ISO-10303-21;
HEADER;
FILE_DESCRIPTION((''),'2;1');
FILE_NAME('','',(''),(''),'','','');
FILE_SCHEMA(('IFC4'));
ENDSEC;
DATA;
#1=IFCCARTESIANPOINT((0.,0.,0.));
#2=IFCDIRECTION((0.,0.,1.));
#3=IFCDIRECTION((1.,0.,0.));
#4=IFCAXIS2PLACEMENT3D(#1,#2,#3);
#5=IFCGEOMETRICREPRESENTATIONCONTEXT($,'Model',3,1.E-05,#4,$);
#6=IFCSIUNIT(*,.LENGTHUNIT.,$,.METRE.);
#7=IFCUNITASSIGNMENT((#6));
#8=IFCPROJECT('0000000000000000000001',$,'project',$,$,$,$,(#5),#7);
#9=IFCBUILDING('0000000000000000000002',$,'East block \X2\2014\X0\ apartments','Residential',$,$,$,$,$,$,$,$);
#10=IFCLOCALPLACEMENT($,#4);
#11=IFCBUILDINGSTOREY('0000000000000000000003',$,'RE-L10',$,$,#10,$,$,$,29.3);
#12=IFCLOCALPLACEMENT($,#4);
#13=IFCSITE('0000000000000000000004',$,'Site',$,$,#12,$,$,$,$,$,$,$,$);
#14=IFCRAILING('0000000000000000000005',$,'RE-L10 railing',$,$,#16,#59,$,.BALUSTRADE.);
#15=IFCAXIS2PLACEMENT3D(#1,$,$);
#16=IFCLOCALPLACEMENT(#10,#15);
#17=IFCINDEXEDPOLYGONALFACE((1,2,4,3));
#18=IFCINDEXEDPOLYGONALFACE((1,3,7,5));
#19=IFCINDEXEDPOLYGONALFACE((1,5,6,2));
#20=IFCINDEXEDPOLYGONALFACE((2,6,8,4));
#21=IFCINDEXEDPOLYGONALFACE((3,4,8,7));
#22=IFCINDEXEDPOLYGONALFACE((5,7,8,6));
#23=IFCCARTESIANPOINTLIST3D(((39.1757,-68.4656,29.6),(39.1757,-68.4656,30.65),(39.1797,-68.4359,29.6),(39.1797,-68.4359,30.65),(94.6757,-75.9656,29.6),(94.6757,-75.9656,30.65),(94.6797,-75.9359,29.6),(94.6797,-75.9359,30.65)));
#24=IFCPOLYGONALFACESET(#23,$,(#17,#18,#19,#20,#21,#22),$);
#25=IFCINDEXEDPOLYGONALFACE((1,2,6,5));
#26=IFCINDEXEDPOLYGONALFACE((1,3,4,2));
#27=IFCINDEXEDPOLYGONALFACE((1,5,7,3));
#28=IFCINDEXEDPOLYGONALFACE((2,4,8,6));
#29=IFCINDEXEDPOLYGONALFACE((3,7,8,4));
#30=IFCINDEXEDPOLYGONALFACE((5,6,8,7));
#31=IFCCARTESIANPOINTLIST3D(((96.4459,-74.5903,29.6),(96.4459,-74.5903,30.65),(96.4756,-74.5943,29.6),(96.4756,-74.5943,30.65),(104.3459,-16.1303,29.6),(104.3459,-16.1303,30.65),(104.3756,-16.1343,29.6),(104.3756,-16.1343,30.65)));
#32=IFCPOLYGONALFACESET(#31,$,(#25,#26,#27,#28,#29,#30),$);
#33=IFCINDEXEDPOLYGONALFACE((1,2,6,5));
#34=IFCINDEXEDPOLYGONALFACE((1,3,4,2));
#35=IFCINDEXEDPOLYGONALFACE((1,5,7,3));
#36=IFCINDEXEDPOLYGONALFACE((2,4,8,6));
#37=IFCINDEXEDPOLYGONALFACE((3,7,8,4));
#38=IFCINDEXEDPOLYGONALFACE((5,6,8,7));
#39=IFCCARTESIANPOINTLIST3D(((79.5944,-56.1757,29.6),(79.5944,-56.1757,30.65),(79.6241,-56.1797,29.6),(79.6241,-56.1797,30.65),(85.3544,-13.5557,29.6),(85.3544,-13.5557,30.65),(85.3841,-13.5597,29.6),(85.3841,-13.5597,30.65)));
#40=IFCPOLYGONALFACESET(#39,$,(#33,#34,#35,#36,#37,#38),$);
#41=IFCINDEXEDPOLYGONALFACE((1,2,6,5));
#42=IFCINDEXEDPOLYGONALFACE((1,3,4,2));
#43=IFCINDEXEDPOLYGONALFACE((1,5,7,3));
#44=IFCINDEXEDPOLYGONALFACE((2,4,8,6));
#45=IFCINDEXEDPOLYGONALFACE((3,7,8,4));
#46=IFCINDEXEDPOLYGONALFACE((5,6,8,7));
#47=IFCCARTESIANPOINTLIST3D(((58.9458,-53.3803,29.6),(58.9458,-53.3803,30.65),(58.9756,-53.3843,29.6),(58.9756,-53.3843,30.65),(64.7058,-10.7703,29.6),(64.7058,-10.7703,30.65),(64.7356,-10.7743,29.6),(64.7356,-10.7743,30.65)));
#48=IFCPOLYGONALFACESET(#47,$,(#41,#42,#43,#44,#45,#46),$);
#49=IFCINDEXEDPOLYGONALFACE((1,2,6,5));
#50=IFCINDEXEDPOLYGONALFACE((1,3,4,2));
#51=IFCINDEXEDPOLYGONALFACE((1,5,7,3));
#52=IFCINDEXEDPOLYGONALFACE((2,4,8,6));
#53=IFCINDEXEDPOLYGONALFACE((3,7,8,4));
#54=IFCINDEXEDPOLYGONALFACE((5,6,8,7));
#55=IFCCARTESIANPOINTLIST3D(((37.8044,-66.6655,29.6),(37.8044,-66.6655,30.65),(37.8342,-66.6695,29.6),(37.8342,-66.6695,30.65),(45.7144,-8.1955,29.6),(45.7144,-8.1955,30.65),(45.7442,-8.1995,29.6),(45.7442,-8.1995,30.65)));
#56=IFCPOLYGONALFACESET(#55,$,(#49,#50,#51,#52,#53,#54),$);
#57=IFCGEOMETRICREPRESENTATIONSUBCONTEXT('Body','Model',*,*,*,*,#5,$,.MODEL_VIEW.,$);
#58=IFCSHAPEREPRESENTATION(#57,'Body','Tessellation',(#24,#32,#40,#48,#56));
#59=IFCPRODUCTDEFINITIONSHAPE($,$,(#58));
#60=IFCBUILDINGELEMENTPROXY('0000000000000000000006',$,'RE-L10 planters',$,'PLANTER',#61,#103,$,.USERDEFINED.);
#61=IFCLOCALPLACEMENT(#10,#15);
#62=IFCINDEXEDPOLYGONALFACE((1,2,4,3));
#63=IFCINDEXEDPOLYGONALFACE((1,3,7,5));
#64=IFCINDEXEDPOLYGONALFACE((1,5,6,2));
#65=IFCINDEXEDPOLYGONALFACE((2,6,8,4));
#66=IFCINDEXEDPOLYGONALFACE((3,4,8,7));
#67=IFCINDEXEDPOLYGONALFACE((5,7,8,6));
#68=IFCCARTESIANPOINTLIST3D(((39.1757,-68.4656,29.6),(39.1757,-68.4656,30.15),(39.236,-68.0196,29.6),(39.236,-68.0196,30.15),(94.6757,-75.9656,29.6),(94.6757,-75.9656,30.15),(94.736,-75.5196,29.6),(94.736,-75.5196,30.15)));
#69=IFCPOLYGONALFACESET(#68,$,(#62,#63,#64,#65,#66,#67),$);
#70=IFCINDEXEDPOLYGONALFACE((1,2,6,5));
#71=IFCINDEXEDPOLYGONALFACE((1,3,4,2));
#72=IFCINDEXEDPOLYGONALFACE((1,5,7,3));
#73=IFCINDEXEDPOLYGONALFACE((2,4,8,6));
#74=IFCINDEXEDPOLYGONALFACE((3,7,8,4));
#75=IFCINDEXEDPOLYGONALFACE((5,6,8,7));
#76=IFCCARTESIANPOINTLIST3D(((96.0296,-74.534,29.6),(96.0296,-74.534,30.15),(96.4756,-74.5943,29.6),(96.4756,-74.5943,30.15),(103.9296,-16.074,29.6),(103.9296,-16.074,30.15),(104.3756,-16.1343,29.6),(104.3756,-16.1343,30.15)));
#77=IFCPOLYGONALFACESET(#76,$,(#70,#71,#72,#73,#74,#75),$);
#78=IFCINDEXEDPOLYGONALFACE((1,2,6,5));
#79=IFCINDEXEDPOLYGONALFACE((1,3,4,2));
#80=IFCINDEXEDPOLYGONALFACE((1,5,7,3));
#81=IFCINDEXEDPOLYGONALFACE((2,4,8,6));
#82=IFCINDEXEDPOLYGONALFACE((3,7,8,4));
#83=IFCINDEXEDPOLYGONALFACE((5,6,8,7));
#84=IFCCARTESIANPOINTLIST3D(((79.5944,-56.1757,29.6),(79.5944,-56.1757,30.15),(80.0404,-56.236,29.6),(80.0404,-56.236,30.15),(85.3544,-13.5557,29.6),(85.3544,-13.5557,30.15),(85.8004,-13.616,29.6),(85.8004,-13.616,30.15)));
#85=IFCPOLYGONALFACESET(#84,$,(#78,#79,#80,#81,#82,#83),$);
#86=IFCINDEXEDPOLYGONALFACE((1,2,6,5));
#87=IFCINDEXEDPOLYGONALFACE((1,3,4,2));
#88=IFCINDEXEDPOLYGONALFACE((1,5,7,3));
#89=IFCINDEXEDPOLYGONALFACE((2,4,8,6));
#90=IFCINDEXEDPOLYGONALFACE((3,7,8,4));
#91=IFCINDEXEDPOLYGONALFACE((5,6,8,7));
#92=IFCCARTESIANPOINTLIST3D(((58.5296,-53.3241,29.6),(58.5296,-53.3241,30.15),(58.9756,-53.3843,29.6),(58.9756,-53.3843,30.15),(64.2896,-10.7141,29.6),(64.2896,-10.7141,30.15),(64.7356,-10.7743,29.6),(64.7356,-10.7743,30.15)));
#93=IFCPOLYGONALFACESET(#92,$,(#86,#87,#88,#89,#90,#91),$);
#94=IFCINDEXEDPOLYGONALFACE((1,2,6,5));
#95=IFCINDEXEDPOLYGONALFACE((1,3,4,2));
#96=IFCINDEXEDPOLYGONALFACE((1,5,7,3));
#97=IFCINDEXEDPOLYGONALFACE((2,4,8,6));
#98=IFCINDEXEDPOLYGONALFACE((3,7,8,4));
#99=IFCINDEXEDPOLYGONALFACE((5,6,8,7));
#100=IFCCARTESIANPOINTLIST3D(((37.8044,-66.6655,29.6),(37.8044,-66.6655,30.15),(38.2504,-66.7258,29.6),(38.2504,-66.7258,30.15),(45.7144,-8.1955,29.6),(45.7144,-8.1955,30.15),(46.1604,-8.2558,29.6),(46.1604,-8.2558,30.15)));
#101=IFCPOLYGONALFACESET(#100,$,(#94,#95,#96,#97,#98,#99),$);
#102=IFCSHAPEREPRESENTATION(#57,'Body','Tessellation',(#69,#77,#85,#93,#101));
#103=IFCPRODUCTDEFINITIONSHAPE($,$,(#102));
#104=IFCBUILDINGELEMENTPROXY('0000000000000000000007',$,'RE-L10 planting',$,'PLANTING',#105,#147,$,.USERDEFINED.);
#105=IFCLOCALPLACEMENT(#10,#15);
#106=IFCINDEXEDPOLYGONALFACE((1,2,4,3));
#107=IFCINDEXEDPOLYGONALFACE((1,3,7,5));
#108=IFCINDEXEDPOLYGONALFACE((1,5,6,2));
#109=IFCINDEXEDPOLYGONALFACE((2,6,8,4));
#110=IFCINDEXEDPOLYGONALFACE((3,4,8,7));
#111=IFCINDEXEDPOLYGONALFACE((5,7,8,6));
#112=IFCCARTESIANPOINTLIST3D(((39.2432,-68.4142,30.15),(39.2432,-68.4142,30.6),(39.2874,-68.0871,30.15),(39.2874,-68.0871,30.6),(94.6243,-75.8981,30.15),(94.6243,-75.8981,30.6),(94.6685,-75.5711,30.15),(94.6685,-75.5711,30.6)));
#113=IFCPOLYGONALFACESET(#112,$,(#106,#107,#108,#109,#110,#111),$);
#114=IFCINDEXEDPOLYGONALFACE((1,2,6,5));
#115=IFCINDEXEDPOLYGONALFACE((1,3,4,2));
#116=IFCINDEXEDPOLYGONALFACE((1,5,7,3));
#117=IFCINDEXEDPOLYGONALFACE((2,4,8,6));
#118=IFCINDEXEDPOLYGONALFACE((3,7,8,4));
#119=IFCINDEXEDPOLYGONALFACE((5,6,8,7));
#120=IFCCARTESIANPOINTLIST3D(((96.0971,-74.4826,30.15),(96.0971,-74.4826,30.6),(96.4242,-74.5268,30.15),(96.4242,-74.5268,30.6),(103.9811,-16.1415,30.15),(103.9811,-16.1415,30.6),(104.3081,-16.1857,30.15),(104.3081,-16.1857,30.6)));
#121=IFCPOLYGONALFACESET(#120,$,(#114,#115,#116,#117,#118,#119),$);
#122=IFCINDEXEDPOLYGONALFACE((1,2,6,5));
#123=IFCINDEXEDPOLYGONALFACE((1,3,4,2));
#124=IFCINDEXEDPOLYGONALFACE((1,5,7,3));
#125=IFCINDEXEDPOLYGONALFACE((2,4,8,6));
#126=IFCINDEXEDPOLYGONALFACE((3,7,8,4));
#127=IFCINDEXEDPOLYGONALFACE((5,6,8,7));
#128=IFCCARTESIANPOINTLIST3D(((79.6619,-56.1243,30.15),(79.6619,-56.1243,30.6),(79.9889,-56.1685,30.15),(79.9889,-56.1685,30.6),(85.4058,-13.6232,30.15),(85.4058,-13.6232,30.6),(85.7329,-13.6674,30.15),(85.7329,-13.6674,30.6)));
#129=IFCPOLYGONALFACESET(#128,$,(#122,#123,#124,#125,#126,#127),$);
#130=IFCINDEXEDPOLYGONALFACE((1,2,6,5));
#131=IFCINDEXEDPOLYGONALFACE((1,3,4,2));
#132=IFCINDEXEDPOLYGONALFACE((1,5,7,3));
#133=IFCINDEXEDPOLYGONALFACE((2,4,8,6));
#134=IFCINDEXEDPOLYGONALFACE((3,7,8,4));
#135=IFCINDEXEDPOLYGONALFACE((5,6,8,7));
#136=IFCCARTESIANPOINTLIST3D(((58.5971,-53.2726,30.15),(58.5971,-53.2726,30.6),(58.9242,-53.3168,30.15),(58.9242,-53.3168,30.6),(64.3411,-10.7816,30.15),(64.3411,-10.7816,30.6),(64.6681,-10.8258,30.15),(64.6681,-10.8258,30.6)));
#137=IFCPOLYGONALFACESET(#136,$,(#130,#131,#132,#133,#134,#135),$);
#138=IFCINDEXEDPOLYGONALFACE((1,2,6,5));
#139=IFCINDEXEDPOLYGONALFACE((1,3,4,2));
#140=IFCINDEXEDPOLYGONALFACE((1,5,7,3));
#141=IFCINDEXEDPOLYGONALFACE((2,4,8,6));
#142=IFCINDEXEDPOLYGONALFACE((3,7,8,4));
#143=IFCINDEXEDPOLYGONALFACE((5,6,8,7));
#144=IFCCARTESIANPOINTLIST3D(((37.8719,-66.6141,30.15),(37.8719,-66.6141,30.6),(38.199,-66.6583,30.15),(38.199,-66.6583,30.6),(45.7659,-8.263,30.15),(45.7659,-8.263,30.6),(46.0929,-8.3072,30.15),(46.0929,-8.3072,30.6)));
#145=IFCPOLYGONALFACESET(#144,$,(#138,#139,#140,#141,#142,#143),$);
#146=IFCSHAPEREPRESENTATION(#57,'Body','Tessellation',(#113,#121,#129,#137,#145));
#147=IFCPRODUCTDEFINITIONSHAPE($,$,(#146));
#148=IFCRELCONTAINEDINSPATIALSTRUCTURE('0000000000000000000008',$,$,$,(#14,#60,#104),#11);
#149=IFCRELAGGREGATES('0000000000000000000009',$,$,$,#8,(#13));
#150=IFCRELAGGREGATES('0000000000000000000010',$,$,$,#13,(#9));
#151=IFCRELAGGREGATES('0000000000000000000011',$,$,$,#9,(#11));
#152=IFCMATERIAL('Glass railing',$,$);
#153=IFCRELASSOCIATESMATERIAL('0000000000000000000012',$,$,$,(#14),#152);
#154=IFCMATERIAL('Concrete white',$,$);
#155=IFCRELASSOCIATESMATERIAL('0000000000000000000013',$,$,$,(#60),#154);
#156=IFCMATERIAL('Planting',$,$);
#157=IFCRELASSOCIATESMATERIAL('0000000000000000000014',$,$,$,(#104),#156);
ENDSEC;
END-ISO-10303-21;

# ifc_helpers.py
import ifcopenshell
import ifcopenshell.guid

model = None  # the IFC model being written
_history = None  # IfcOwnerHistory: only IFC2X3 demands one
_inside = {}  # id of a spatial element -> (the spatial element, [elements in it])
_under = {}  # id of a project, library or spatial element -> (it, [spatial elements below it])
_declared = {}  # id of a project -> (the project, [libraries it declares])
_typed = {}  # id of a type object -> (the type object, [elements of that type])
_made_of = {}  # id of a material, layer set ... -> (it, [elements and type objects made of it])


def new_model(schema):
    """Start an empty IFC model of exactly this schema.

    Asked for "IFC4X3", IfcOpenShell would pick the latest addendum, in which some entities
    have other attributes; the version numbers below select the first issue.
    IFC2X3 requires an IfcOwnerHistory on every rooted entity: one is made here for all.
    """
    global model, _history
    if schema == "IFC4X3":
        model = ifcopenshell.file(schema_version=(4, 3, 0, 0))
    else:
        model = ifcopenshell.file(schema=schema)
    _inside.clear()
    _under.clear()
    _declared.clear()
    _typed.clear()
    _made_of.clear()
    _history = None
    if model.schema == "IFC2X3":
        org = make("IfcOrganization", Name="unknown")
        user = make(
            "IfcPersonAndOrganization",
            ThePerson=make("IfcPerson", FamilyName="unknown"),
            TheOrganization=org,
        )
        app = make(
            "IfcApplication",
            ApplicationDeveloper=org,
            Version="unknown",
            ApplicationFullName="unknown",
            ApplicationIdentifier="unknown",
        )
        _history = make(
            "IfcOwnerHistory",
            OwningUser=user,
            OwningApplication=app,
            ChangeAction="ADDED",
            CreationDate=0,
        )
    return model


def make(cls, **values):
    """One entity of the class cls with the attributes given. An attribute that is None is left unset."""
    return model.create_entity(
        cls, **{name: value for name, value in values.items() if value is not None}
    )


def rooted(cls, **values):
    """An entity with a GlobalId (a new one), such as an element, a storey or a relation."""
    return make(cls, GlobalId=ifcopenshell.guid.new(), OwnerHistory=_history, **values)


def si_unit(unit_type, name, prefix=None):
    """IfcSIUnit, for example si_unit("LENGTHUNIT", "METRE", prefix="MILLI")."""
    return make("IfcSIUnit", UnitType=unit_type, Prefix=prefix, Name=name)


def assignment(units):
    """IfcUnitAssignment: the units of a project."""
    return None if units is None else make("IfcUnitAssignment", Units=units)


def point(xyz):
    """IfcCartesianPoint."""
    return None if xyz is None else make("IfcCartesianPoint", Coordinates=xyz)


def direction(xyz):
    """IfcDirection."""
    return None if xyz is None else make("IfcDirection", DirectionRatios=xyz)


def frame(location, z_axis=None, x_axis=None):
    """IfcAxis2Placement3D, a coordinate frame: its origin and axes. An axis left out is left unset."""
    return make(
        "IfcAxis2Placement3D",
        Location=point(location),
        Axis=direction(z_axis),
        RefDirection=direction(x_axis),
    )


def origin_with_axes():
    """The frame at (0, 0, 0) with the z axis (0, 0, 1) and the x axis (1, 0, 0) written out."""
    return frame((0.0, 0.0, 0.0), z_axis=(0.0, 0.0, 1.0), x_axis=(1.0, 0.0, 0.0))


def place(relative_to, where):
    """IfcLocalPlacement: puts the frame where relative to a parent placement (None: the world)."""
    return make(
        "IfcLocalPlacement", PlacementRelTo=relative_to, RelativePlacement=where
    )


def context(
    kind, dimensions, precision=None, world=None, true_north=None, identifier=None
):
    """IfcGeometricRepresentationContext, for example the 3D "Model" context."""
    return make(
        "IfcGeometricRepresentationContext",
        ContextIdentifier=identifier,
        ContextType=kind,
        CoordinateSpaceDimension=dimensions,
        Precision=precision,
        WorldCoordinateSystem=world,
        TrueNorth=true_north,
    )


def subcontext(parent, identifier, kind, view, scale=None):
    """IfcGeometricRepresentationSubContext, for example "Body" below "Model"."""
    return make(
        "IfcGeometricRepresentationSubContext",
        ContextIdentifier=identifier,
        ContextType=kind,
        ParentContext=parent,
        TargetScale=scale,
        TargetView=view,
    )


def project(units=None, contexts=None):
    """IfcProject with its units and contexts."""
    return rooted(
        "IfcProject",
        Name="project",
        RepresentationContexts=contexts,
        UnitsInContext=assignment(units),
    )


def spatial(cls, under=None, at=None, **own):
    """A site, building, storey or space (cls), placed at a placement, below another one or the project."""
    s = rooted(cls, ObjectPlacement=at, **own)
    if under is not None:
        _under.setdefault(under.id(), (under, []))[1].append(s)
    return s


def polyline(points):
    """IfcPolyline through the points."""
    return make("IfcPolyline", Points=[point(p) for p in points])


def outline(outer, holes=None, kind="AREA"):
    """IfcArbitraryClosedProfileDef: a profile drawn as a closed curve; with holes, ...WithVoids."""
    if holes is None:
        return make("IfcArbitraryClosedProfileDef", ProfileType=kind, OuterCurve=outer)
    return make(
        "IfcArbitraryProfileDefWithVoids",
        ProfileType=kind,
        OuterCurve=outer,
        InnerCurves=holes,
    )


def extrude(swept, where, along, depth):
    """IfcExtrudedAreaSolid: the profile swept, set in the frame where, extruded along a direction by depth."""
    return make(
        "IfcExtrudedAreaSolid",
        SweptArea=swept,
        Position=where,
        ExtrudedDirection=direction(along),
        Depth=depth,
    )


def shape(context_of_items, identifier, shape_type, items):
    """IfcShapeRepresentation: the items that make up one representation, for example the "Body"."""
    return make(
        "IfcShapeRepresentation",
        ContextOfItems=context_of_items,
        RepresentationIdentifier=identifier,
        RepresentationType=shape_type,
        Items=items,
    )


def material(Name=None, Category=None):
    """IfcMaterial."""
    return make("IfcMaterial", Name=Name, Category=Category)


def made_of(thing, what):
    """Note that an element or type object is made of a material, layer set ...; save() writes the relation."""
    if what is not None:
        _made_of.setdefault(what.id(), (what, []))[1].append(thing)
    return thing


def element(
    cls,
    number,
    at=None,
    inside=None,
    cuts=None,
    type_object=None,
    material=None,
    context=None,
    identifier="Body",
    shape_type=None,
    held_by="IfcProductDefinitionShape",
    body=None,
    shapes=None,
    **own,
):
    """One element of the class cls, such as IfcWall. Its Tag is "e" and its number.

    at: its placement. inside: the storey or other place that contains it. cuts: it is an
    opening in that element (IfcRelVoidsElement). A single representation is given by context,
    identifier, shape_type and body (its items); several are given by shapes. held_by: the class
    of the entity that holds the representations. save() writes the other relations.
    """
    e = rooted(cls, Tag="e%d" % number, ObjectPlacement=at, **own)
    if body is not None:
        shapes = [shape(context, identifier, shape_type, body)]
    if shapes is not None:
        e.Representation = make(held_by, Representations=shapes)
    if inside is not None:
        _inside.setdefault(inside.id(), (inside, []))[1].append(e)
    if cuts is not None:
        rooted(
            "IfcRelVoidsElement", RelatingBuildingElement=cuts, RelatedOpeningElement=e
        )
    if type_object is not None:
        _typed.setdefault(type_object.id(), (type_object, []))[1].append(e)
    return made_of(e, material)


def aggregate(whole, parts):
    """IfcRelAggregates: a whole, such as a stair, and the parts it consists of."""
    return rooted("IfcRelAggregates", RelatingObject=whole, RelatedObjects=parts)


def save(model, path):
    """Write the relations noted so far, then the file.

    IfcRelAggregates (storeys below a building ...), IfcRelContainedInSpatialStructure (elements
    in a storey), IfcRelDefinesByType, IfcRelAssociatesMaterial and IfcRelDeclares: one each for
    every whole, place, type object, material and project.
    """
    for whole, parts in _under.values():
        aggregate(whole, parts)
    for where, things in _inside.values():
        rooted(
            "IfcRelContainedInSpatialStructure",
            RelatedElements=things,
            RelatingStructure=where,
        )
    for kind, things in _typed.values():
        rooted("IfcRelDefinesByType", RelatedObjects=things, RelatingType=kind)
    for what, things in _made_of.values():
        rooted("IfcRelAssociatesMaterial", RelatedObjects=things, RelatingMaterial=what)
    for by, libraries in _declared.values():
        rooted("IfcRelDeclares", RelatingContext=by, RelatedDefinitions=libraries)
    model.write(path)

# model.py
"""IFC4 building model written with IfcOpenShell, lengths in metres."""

from ifc_helpers import new_model, si_unit, frame, origin_with_axes, place, context, subcontext, project, spatial, polyline, outline, extrude, material, element, save


model = new_model("IFC4")

# Units and contexts
model_context = context("Model", 3, precision=1e-05, world=origin_with_axes())
body_context = subcontext(model_context, "Body", "Model", "MODEL_VIEW")
ifc_project = project(units=[si_unit("LENGTHUNIT", "METRE")], contexts=[model_context])

# Site, building, storey
site_placement = place(None, origin_with_axes())
site = spatial("IfcSite", under=ifc_project, at=site_placement, Name="Site")
building = spatial("IfcBuilding", under=site, Name="East block — apartments", Description="Residential")
storey_placement = place(None, origin_with_axes())
storey = spatial("IfcBuildingStorey", under=building, at=storey_placement, Name="RE-L10", Elevation=29.3)

# Railing
ifc_material_1 = material(Name="Glass railing")
railing_placement = place(storey_placement, origin_with_axes())
element("IfcRailing", 1, at=railing_placement, inside=storey, material=ifc_material_1, Name="RE-L10 railing", PredefinedType="BALUSTRADE", context=body_context, shape_type="SweptSolid", body=[
    extrude(outline(polyline([(39.1757, -68.4656), (94.6757, -75.9656), (94.6797, -75.9359), (39.1797, -68.4359), (39.1757, -68.4656)])), frame((0.0, 0.0, 29.6), z_axis=(0.0, 0.0, 1.0), x_axis=(1.0, 0.0, 0.0)), (0.0, 0.0, 1.0), 1.05),
    extrude(outline(polyline([(96.4756, -74.5943), (104.3756, -16.1343), (104.3459, -16.1303), (96.4459, -74.5903), (96.4756, -74.5943)])), frame((0.0, 0.0, 29.6), z_axis=(0.0, 0.0, 1.0), x_axis=(1.0, 0.0, 0.0)), (0.0, 0.0, 1.0), 1.05),
    extrude(outline(polyline([(85.3544, -13.5557), (79.5944, -56.1757), (79.6241, -56.1797), (85.3841, -13.5597), (85.3544, -13.5557)])), frame((0.0, 0.0, 29.6), z_axis=(0.0, 0.0, 1.0), x_axis=(1.0, 0.0, 0.0)), (0.0, 0.0, 1.0), 1.05),
    extrude(outline(polyline([(58.9756, -53.3843), (64.7356, -10.7743), (64.7058, -10.7703), (58.9458, -53.3803), (58.9756, -53.3843)])), frame((0.0, 0.0, 29.6), z_axis=(0.0, 0.0, 1.0), x_axis=(1.0, 0.0, 0.0)), (0.0, 0.0, 1.0), 1.05),
    extrude(outline(polyline([(45.7144, -8.1955), (37.8044, -66.6655), (37.8342, -66.6695), (45.7442, -8.1995), (45.7144, -8.1955)])), frame((0.0, 0.0, 29.6), z_axis=(0.0, 0.0, 1.0), x_axis=(1.0, 0.0, 0.0)), (0.0, 0.0, 1.0), 1.05),
])

# Building element proxies
ifc_material_2 = material(Name="Concrete white")
proxy_1_placement = place(storey_placement, origin_with_axes())
element("IfcBuildingElementProxy", 2, at=proxy_1_placement, inside=storey, material=ifc_material_2, Name="RE-L10 planters", ObjectType="PLANTER", PredefinedType="USERDEFINED", context=body_context, shape_type="SweptSolid", body=[
    extrude(outline(polyline([(39.1757, -68.4656), (94.6757, -75.9656), (94.736, -75.5196), (39.236, -68.0196), (39.1757, -68.4656)])), frame((0.0, 0.0, 29.6), z_axis=(0.0, 0.0, 1.0), x_axis=(1.0, 0.0, 0.0)), (0.0, 0.0, 1.0), 0.55),
    extrude(outline(polyline([(96.4756, -74.5943), (104.3756, -16.1343), (103.9296, -16.074), (96.0296, -74.534), (96.4756, -74.5943)])), frame((0.0, 0.0, 29.6), z_axis=(0.0, 0.0, 1.0), x_axis=(1.0, 0.0, 0.0)), (0.0, 0.0, 1.0), 0.55),
    extrude(outline(polyline([(85.3544, -13.5557), (79.5944, -56.1757), (80.0404, -56.236), (85.8004, -13.616), (85.3544, -13.5557)])), frame((0.0, 0.0, 29.6), z_axis=(0.0, 0.0, 1.0), x_axis=(1.0, 0.0, 0.0)), (0.0, 0.0, 1.0), 0.55),
    extrude(outline(polyline([(58.9756, -53.3843), (64.7356, -10.7743), (64.2896, -10.7141), (58.5296, -53.3241), (58.9756, -53.3843)])), frame((0.0, 0.0, 29.6), z_axis=(0.0, 0.0, 1.0), x_axis=(1.0, 0.0, 0.0)), (0.0, 0.0, 1.0), 0.55),
    extrude(outline(polyline([(45.7144, -8.1955), (37.8044, -66.6655), (38.2504, -66.7258), (46.1604, -8.2558), (45.7144, -8.1955)])), frame((0.0, 0.0, 29.6), z_axis=(0.0, 0.0, 1.0), x_axis=(1.0, 0.0, 0.0)), (0.0, 0.0, 1.0), 0.55),
])
ifc_material_3 = material(Name="Planting")
proxy_2_placement = place(storey_placement, origin_with_axes())
element("IfcBuildingElementProxy", 3, at=proxy_2_placement, inside=storey, material=ifc_material_3, Name="RE-L10 planting", ObjectType="PLANTING", PredefinedType="USERDEFINED", context=body_context, shape_type="SweptSolid", body=[
    extrude(outline(polyline([(39.2432, -68.4142), (94.6243, -75.8981), (94.6685, -75.5711), (39.2874, -68.0871), (39.2432, -68.4142)])), frame((0.0, 0.0, 30.15), z_axis=(0.0, 0.0, 1.0), x_axis=(1.0, 0.0, 0.0)), (0.0, 0.0, 1.0), 0.45),
    extrude(outline(polyline([(96.4242, -74.5268), (104.3081, -16.1857), (103.9811, -16.1415), (96.0971, -74.4826), (96.4242, -74.5268)])), frame((0.0, 0.0, 30.15), z_axis=(0.0, 0.0, 1.0), x_axis=(1.0, 0.0, 0.0)), (0.0, 0.0, 1.0), 0.45),
    extrude(outline(polyline([(85.4058, -13.6232), (79.6619, -56.1243), (79.9889, -56.1685), (85.7329, -13.6674), (85.4058, -13.6232)])), frame((0.0, 0.0, 30.15), z_axis=(0.0, 0.0, 1.0), x_axis=(1.0, 0.0, 0.0)), (0.0, 0.0, 1.0), 0.45),
    extrude(outline(polyline([(58.9242, -53.3168), (64.6681, -10.8258), (64.3411, -10.7816), (58.5971, -53.2726), (58.9242, -53.3168)])), frame((0.0, 0.0, 30.15), z_axis=(0.0, 0.0, 1.0), x_axis=(1.0, 0.0, 0.0)), (0.0, 0.0, 1.0), 0.45),
    extrude(outline(polyline([(45.7659, -8.263), (37.8719, -66.6141), (38.199, -66.6583), (46.0929, -8.3072), (45.7659, -8.263)])), frame((0.0, 0.0, 30.15), z_axis=(0.0, 0.0, 1.0), x_axis=(1.0, 0.0, 0.0)), (0.0, 0.0, 1.0), 0.45),
])

save(model, "model.ifc")
